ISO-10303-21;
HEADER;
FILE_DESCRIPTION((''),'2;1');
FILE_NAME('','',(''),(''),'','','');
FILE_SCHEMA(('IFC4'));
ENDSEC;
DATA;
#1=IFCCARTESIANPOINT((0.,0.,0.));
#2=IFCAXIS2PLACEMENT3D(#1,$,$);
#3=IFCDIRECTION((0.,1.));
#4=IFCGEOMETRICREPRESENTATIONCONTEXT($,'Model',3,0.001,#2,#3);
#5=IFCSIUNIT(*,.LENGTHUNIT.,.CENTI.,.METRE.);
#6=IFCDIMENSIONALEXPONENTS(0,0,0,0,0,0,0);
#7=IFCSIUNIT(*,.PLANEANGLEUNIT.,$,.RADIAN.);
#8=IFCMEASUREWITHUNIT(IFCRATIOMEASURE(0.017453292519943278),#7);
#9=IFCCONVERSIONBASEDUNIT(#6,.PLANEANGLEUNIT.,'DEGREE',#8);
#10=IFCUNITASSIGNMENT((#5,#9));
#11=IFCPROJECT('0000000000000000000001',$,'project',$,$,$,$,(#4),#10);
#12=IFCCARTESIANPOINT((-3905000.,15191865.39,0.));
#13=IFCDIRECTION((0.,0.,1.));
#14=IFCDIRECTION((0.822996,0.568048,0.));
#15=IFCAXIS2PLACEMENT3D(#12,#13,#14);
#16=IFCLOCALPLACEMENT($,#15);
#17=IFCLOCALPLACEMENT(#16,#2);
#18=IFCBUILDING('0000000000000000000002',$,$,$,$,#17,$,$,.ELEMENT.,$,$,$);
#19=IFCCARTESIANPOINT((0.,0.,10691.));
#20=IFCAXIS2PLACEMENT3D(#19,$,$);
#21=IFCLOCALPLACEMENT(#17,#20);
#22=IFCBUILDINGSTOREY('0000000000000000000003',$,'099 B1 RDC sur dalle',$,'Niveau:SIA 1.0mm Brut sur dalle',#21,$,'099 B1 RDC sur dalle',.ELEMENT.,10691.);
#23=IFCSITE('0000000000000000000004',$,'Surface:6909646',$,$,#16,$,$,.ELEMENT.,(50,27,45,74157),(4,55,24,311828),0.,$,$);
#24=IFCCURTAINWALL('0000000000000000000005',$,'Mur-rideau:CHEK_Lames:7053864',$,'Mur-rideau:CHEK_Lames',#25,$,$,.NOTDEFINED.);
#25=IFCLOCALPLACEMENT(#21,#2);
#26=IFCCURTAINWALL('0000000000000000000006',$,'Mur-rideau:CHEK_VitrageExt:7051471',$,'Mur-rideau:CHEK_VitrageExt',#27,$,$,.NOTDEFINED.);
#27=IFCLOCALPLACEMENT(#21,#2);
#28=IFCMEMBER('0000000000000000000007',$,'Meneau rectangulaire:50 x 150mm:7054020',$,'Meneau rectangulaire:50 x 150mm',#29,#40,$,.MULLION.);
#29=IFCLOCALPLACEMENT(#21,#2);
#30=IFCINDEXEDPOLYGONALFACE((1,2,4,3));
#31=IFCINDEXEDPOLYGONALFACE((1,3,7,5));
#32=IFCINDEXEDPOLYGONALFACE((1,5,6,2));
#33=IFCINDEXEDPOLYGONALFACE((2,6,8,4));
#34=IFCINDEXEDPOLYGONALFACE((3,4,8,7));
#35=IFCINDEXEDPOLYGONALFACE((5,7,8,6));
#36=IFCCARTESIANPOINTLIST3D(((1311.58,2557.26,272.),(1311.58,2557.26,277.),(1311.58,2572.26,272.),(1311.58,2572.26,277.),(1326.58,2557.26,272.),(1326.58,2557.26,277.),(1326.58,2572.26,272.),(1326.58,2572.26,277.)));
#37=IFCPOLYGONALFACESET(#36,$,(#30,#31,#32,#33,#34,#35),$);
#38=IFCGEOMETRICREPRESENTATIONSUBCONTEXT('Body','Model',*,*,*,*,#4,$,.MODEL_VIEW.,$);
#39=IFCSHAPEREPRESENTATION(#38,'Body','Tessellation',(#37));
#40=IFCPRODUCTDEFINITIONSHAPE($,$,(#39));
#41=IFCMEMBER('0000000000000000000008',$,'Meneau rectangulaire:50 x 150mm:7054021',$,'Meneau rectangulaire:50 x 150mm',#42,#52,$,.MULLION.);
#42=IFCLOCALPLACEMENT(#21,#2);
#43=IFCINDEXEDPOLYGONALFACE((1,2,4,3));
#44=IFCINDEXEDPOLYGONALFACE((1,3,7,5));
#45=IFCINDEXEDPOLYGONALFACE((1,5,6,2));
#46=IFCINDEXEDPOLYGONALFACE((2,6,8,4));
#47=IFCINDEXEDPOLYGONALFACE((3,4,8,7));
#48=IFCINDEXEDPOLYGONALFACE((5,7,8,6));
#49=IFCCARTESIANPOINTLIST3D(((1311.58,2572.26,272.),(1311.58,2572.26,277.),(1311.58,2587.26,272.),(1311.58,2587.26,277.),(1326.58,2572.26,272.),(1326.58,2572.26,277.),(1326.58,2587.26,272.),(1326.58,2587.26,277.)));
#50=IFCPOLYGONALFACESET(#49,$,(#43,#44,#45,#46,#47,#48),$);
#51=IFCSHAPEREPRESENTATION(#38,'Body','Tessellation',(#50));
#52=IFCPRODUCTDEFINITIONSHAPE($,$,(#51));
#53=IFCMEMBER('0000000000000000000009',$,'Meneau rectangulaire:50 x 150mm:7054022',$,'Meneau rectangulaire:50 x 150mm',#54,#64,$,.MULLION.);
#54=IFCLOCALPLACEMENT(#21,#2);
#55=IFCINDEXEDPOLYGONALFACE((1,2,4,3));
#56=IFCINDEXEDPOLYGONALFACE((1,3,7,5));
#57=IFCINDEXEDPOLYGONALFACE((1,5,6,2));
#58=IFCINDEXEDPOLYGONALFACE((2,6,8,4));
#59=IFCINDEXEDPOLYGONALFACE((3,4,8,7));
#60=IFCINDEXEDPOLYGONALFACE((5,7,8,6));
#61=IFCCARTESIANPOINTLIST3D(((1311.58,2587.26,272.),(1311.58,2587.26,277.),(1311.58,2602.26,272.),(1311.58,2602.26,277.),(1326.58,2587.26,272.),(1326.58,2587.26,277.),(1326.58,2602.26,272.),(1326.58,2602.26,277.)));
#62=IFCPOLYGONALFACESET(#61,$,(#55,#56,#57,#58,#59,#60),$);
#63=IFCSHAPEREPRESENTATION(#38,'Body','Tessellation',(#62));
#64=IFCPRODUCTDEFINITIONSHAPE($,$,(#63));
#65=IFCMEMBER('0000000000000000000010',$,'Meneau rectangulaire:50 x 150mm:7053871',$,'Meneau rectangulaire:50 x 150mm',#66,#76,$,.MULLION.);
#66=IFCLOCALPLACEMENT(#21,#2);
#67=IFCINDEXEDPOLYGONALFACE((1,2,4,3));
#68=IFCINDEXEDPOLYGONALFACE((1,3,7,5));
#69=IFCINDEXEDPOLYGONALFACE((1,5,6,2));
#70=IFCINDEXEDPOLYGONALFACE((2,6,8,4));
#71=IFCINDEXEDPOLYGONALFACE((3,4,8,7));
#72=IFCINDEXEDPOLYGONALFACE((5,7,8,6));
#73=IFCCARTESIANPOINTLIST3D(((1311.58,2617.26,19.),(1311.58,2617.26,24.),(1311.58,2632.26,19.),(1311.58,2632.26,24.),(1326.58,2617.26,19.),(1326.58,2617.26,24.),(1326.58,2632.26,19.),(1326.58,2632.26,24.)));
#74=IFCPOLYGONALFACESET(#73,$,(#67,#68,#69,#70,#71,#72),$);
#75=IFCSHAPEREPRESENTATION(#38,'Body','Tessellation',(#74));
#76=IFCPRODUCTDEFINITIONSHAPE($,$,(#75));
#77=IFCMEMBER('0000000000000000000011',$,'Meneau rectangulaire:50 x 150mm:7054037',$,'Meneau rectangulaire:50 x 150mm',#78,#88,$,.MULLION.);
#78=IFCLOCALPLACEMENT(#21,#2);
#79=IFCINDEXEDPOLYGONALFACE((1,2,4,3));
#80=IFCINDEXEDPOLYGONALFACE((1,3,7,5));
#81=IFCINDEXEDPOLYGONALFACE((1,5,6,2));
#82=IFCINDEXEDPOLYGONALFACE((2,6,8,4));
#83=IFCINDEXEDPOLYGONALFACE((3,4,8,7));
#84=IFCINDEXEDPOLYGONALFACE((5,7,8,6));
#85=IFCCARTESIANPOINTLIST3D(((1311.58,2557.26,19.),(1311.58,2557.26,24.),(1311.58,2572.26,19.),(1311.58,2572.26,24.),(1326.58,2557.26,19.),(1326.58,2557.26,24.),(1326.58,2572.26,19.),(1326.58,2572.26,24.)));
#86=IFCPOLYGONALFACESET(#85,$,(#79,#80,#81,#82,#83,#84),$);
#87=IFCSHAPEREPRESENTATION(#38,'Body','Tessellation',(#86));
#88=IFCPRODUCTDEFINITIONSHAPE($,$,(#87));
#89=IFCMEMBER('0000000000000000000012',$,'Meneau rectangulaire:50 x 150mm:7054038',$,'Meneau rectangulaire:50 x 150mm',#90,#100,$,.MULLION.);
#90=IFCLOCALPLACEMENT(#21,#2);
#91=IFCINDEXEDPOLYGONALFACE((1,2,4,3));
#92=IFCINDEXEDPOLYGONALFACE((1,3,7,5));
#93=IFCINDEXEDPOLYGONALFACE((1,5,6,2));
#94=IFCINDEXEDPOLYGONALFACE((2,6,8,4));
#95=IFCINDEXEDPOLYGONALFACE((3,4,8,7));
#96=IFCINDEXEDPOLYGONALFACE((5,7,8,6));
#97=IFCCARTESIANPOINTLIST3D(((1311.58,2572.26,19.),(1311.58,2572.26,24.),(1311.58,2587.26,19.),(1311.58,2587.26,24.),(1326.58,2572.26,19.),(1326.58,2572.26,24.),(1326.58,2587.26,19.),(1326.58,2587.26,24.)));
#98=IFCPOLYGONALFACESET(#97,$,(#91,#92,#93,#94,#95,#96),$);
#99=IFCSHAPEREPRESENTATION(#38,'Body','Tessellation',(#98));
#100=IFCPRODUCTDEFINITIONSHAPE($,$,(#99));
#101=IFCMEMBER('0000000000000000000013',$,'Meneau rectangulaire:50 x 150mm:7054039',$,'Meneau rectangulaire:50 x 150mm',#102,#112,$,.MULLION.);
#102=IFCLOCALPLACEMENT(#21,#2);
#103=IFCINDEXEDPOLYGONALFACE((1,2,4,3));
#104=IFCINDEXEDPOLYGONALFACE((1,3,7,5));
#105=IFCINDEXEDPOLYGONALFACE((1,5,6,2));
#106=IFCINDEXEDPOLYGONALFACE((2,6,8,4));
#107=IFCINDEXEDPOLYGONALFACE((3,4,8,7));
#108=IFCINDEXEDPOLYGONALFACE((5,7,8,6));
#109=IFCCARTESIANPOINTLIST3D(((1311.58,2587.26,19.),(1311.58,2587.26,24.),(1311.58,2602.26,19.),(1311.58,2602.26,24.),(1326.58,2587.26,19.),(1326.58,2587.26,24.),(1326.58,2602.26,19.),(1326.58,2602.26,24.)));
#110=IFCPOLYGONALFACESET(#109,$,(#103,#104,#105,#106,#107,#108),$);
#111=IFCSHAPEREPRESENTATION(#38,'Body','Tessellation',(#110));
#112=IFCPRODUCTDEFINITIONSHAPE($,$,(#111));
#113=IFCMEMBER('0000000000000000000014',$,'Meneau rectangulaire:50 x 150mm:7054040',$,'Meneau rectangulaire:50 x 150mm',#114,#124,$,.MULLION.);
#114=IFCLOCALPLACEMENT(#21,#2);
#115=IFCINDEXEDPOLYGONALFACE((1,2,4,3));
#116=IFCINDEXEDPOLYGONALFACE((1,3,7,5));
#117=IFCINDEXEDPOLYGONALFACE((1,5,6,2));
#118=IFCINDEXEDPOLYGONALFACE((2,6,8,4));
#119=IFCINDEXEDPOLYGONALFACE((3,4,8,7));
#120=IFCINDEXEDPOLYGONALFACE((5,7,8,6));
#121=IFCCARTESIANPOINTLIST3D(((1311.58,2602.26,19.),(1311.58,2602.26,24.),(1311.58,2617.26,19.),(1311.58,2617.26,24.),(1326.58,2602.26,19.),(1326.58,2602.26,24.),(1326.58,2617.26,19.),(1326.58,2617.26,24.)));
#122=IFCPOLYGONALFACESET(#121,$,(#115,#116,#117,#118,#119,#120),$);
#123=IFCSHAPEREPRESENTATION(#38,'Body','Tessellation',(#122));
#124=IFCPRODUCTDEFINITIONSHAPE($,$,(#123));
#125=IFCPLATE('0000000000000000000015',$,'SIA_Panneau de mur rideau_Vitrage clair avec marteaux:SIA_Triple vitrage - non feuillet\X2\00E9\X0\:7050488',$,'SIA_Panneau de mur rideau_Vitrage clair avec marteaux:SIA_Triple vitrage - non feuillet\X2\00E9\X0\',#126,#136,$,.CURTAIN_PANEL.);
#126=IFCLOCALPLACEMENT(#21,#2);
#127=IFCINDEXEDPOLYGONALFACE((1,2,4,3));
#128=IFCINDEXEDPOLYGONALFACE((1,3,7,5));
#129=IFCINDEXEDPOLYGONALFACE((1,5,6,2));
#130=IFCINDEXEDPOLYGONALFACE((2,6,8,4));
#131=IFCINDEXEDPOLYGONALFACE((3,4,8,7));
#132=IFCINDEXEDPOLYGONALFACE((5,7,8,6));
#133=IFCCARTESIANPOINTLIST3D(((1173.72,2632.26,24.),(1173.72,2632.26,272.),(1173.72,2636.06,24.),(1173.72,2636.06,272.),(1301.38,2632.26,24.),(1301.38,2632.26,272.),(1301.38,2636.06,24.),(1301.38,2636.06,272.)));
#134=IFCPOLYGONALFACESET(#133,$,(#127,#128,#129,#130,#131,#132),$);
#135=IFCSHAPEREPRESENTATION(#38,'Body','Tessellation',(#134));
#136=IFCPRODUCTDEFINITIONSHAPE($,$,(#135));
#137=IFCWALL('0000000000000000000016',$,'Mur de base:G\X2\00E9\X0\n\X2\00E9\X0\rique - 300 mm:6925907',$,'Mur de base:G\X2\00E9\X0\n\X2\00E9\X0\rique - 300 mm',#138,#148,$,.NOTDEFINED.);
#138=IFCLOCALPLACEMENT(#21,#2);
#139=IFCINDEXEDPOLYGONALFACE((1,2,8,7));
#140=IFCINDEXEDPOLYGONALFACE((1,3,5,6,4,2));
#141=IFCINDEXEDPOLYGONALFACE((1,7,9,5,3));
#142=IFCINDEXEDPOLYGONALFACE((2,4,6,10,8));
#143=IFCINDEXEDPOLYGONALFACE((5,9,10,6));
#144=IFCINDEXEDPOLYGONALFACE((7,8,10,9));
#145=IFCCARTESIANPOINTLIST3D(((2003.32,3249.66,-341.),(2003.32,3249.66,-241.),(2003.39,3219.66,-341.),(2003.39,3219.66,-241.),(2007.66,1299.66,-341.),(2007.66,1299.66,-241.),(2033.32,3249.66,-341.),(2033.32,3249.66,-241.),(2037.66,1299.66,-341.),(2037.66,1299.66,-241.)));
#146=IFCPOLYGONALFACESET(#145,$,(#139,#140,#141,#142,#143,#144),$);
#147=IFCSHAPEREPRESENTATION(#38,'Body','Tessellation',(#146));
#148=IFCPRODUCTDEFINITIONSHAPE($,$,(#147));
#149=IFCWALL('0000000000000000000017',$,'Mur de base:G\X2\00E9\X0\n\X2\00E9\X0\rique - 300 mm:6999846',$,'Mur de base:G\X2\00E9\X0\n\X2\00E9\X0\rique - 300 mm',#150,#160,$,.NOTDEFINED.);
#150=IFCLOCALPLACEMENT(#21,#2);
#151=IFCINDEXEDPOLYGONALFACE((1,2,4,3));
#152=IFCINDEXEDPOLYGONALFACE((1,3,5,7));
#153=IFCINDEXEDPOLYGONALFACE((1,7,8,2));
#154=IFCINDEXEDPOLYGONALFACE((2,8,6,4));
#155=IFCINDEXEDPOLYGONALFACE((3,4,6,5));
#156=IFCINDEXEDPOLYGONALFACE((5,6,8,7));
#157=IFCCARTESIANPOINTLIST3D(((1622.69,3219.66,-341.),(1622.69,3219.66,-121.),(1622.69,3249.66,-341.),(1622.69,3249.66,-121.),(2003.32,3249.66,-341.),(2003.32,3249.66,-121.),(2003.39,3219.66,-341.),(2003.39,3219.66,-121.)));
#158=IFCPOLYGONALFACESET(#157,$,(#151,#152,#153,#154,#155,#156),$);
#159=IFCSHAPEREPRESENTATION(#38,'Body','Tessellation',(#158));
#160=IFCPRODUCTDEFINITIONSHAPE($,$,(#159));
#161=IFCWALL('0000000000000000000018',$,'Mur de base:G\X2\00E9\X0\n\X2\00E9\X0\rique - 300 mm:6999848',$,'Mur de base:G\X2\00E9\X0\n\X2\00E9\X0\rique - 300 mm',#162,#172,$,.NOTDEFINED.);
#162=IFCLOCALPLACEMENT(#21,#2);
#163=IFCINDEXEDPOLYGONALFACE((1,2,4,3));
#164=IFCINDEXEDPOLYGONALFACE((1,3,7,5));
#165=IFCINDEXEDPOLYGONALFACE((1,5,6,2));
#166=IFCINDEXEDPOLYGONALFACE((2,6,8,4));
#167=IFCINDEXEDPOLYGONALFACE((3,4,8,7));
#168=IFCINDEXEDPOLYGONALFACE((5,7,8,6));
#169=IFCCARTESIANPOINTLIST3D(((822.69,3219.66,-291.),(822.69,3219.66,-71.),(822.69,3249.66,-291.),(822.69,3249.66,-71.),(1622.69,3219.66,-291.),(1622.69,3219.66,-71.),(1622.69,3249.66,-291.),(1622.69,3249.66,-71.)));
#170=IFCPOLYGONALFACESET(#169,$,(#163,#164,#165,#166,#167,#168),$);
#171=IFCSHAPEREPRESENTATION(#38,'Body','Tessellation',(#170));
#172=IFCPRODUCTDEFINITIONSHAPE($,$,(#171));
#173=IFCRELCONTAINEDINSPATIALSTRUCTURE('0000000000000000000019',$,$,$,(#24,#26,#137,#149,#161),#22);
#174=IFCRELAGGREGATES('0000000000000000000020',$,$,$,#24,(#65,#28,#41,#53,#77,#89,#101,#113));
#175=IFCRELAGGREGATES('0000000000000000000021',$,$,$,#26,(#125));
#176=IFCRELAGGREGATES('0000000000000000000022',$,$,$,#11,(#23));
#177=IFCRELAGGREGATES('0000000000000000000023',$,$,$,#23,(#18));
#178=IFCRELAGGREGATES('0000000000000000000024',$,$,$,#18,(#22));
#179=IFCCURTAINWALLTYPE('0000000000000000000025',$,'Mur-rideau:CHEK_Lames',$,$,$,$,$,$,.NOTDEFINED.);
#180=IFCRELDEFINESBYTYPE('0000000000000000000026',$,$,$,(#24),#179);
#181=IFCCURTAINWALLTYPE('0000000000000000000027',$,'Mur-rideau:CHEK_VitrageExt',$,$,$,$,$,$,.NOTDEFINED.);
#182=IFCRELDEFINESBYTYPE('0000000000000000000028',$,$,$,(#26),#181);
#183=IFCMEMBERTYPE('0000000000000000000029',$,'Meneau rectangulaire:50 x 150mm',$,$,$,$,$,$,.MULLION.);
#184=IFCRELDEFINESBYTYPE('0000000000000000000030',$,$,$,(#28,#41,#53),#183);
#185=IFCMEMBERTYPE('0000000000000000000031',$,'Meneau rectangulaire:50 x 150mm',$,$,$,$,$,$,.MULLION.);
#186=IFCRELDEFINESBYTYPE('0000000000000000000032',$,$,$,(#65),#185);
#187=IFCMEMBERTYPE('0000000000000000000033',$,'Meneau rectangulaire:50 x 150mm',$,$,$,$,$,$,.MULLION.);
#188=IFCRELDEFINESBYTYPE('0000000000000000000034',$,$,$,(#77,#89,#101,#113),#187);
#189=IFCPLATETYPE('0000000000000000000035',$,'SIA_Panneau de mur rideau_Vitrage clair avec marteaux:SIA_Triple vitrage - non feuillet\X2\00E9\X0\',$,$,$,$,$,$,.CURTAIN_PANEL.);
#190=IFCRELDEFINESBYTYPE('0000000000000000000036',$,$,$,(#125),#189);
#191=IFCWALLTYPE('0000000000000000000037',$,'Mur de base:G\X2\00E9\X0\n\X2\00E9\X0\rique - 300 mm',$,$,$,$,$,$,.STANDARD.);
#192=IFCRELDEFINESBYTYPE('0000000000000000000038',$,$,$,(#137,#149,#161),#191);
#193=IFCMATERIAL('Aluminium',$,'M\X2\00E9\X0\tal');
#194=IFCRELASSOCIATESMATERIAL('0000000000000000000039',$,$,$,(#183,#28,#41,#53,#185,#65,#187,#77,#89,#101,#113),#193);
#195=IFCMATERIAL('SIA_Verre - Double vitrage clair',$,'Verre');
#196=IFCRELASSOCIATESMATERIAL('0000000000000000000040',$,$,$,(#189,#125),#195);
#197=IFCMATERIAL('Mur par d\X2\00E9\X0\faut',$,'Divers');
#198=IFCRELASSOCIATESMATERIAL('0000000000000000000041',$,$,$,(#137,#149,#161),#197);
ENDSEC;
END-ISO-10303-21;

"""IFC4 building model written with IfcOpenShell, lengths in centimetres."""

from ifc_helpers import new_model, entity, si_unit, converted_unit, direction, frame, origin, place, context, subcontext, project, spatial, indexed_curve, outline, extrude, source, transform, mapped, material, type_object, type_shapes, element, aggregate, save


model = new_model("IFC4")

# Units and contexts
model_context = context("Model", 3, precision=0.001, world=origin(), true_north=direction((0.0, 1.0)))
body_context = subcontext(model_context, "Body", "Model", "MODEL_VIEW")
ifc_project = project(units=[si_unit("LENGTHUNIT", "METRE", prefix="CENTI"), converted_unit("PLANEANGLEUNIT", "DEGREE", entity("IfcRatioMeasure", 0.017453292519943278), si_unit("PLANEANGLEUNIT", "RADIAN"), dimensions=[0, 0, 0, 0, 0, 0, 0])], contexts=[model_context])

# Site, building, storey
site_placement = place(None, frame((-3905000.0, 15191865.39, 0.0), z_axis=(0.0, 0.0, 1.0), x_axis=(0.822996, 0.568048, 0.0)))
site = spatial("IfcSite", under=ifc_project, at=site_placement, Name="Surface:6909646", CompositionType="ELEMENT", RefLatitude=(50, 27, 45, 74157), RefLongitude=(4, 55, 24, 311828), RefElevation=0.0)
building_placement = place(site_placement, origin())
building = spatial("IfcBuilding", under=site, at=building_placement, CompositionType="ELEMENT")
storey_placement = place(building_placement, frame((0.0, 0.0, 10691.0)))
storey = spatial("IfcBuildingStorey", under=building, at=storey_placement, Name="099 B1 RDC sur dalle", ObjectType="Niveau:SIA 1.0mm Brut sur dalle", LongName="099 B1 RDC sur dalle", CompositionType="ELEMENT", Elevation=10691.0)

# Curtain wall
curtain_wall_type_1 = type_object("IfcCurtainWallType", Name="Mur-rideau:CHEK_Lames", PredefinedType="NOTDEFINED")
curtain_wall_1_placement = place(storey_placement, frame((0.0, 0.0, -10691.0)))
curtain_wall_1 = element("IfcCurtainWall", 1, at=curtain_wall_1_placement, inside=storey, type_object=curtain_wall_type_1, Name="Mur-rideau:CHEK_Lames:7053864", ObjectType="Mur-rideau:CHEK_Lames", PredefinedType="NOTDEFINED")
ifc_material_1 = material(Name="Aluminium", Category="Métal")

# Curtain wall
curtain_wall_type_2 = type_object("IfcCurtainWallType", Name="Mur-rideau:CHEK_VitrageExt", PredefinedType="NOTDEFINED")
curtain_wall_2_placement = place(storey_placement, frame((0.0, 0.0, -10691.0)))
curtain_wall_2 = element("IfcCurtainWall", 2, at=curtain_wall_2_placement, inside=storey, type_object=curtain_wall_type_2, Name="Mur-rideau:CHEK_VitrageExt:7051471", ObjectType="Mur-rideau:CHEK_VitrageExt", PredefinedType="NOTDEFINED")

# Members
member_type_1 = type_object("IfcMemberType", Name="Meneau rectangulaire:50 x 150mm", PredefinedType="MULLION", material=ifc_material_1)
shared_shape_1 = source(origin(), body_context, "Body", "SweptSolid", [
    extrude(outline(indexed_curve([(-7.5, -2.5), (7.5, -2.5), (7.5, 2.5), (-7.5, 2.5), (-7.5, -2.5)], self_intersect=False)), frame((-2.5, -6.0, -15.0), z_axis=(0.0, 0.0, 1.0), x_axis=(0.0, -1.0, 0.0)), (0.0, 0.0, 1.0), 15.0),
])
type_shapes(member_type_1, [shared_shape_1])
member_1_placement = place(curtain_wall_1_placement, frame((1325.08, 2572.26, 10968.0), z_axis=(0.0, 1.0, 0.0), x_axis=(0.0, 0.0, 1.0)))
member_1 = element("IfcMember", 3, at=member_1_placement, type_object=member_type_1, material=ifc_material_1, Name="Meneau rectangulaire:50 x 150mm:7054020", ObjectType="Meneau rectangulaire:50 x 150mm", PredefinedType="MULLION", context=body_context, shape_type="MappedRepresentation", body=[
    mapped(shared_shape_1, transform((0.0, 0.0, 0.0), scale=1.0)),
])
member_2_placement = place(curtain_wall_1_placement, frame((1325.08, 2587.26, 10968.0), z_axis=(0.0, 1.0, 0.0), x_axis=(0.0, 0.0, 1.0)))
member_2 = element("IfcMember", 4, at=member_2_placement, type_object=member_type_1, material=ifc_material_1, Name="Meneau rectangulaire:50 x 150mm:7054021", ObjectType="Meneau rectangulaire:50 x 150mm", PredefinedType="MULLION", context=body_context, shape_type="MappedRepresentation", body=[
    mapped(shared_shape_1, transform((0.0, 0.0, 0.0), scale=1.0)),
])
member_3_placement = place(curtain_wall_1_placement, frame((1325.08, 2602.26, 10968.0), z_axis=(0.0, 1.0, 0.0), x_axis=(0.0, 0.0, 1.0)))
member_3 = element("IfcMember", 5, at=member_3_placement, type_object=member_type_1, material=ifc_material_1, Name="Meneau rectangulaire:50 x 150mm:7054022", ObjectType="Meneau rectangulaire:50 x 150mm", PredefinedType="MULLION", context=body_context, shape_type="MappedRepresentation", body=[
    mapped(shared_shape_1, transform((0.0, 0.0, 0.0), scale=1.0)),
])
member_type_2 = type_object("IfcMemberType", Name="Meneau rectangulaire:50 x 150mm", PredefinedType="MULLION", material=ifc_material_1)
shared_shape_2 = source(origin(), body_context, "Body", "SweptSolid", [
    extrude(outline(indexed_curve([(-7.5, -2.5), (7.5, -2.5), (7.5, 2.5), (-7.5, 2.5), (-7.5, -2.5)], self_intersect=False)), frame((-2.5, -6.0, -15.0), z_axis=(0.0, 0.0, 1.0), x_axis=(0.0, -1.0, 0.0)), (0.0, 0.0, 1.0), 15.0),
])
type_shapes(member_type_2, [shared_shape_2])
member_4_placement = place(curtain_wall_1_placement, frame((1325.08, 2617.26, 10710.0), z_axis=(0.0, -1.0, 0.0), x_axis=(0.0, 0.0, -1.0)))
member_4 = element("IfcMember", 6, at=member_4_placement, type_object=member_type_2, material=ifc_material_1, Name="Meneau rectangulaire:50 x 150mm:7053871", ObjectType="Meneau rectangulaire:50 x 150mm", PredefinedType="MULLION", context=body_context, shape_type="MappedRepresentation", body=[
    mapped(shared_shape_2, transform((0.0, 0.0, 0.0), scale=1.0)),
])
member_type_3 = type_object("IfcMemberType", Name="Meneau rectangulaire:50 x 150mm", PredefinedType="MULLION", material=ifc_material_1)
shared_shape_3 = source(origin(), body_context, "Body", "SweptSolid", [
    extrude(outline(indexed_curve([(-7.5, -2.5), (7.5, -2.5), (7.5, 2.5), (-7.5, 2.5), (-7.5, -2.5)], self_intersect=False)), frame((-2.5, -6.0, -15.0), z_axis=(0.0, 0.0, 1.0), x_axis=(0.0, -1.0, 0.0)), (0.0, 0.0, 1.0), 15.0),
])
type_shapes(member_type_3, [shared_shape_3])
member_5_placement = place(curtain_wall_1_placement, frame((1325.08, 2557.26, 10710.0), z_axis=(0.0, -1.0, 0.0), x_axis=(0.0, 0.0, -1.0)))
member_5 = element("IfcMember", 7, at=member_5_placement, type_object=member_type_3, material=ifc_material_1, Name="Meneau rectangulaire:50 x 150mm:7054037", ObjectType="Meneau rectangulaire:50 x 150mm", PredefinedType="MULLION", context=body_context, shape_type="MappedRepresentation", body=[
    mapped(shared_shape_3, transform((0.0, 0.0, 0.0), scale=1.0)),
])
member_6_placement = place(curtain_wall_1_placement, frame((1325.08, 2572.26, 10710.0), z_axis=(0.0, -1.0, 0.0), x_axis=(0.0, 0.0, -1.0)))
member_6 = element("IfcMember", 8, at=member_6_placement, type_object=member_type_3, material=ifc_material_1, Name="Meneau rectangulaire:50 x 150mm:7054038", ObjectType="Meneau rectangulaire:50 x 150mm", PredefinedType="MULLION", context=body_context, shape_type="MappedRepresentation", body=[
    mapped(shared_shape_3, transform((0.0, 0.0, 0.0), scale=1.0)),
])
member_7_placement = place(curtain_wall_1_placement, frame((1325.08, 2587.26, 10710.0), z_axis=(0.0, -1.0, 0.0), x_axis=(0.0, 0.0, -1.0)))
member_7 = element("IfcMember", 9, at=member_7_placement, type_object=member_type_3, material=ifc_material_1, Name="Meneau rectangulaire:50 x 150mm:7054039", ObjectType="Meneau rectangulaire:50 x 150mm", PredefinedType="MULLION", context=body_context, shape_type="MappedRepresentation", body=[
    mapped(shared_shape_3, transform((0.0, 0.0, 0.0), scale=1.0)),
])
member_8_placement = place(curtain_wall_1_placement, frame((1325.08, 2602.26, 10710.0), z_axis=(0.0, -1.0, 0.0), x_axis=(0.0, 0.0, -1.0)))
member_8 = element("IfcMember", 10, at=member_8_placement, type_object=member_type_3, material=ifc_material_1, Name="Meneau rectangulaire:50 x 150mm:7054040", ObjectType="Meneau rectangulaire:50 x 150mm", PredefinedType="MULLION", context=body_context, shape_type="MappedRepresentation", body=[
    mapped(shared_shape_3, transform((0.0, 0.0, 0.0), scale=1.0)),
])
aggregate(curtain_wall_1, [member_4, member_1, member_2, member_3, member_5, member_6, member_7, member_8])

# Plate
ifc_material_2 = material(Name="SIA_Verre - Double vitrage clair", Category="Verre")
plate_type = type_object("IfcPlateType", Name="SIA_Panneau de mur rideau_Vitrage clair avec marteaux:SIA_Triple vitrage - non feuilleté", PredefinedType="CURTAIN_PANEL", material=ifc_material_2)
shared_shape_4 = source(origin(), body_context, "Body", "SweptSolid", [
    extrude(outline(indexed_curve([(-63.83, -1.9), (63.83, -1.9), (63.83, 1.9), (-63.83, 1.9), (-63.83, -1.9)], self_intersect=False)), frame((0.0, 1.9, 0.0), z_axis=(0.0, 0.0, 1.0), x_axis=(-1.0, 0.0, 0.0)), (0.0, 0.0, 1.0), 248.0),
])
type_shapes(plate_type, [shared_shape_4])
plate_placement = place(curtain_wall_2_placement, frame((1237.55, 2632.26, 10715.0)))
plate = element("IfcPlate", 11, at=plate_placement, type_object=plate_type, material=ifc_material_2, Name="SIA_Panneau de mur rideau_Vitrage clair avec marteaux:SIA_Triple vitrage - non feuilleté:7050488", ObjectType="SIA_Panneau de mur rideau_Vitrage clair avec marteaux:SIA_Triple vitrage - non feuilleté", PredefinedType="CURTAIN_PANEL", context=body_context, shape_type="MappedRepresentation", body=[
    mapped(shared_shape_4, transform((0.0, 0.0, 0.0), scale=1.0)),
])
aggregate(curtain_wall_2, [plate])

# Walls
ifc_material_3 = material(Name="Mur par défaut", Category="Divers")
wall_type_1 = type_object("IfcWallType", Name="Mur de base:Générique - 300 mm", PredefinedType="STANDARD")
wall_1_placement = place(storey_placement, frame((2018.32, 3249.7, -341.0), z_axis=(0.0, 0.0, 1.0), x_axis=(0.002225, -0.999998, 0.0)))
element("IfcWall", 12, at=wall_1_placement, inside=storey, type_object=wall_type_1, material=ifc_material_3, Name="Mur de base:Générique - 300 mm:6925907", ObjectType="Mur de base:Générique - 300 mm", PredefinedType="NOTDEFINED", context=body_context, shape_type="SweptSolid", body=[
    extrude(outline(indexed_curve([(1950.0, -15.0), (1950.07, 15.0), (0.07, 15.0), (0.0, -15.0), (30.0, -15.0), (1950.0, -15.0)], self_intersect=False)), origin(), (0.0, 0.0, 1.0), 100.0),
])
wall_2_placement = place(storey_placement, frame((2003.39, 3234.66, -341.0), z_axis=(0.0, 0.0, 1.0), x_axis=(-1.0, 0.0, 0.0)))
element("IfcWall", 13, at=wall_2_placement, inside=storey, type_object=wall_type_1, material=ifc_material_3, Name="Mur de base:Générique - 300 mm:6999846", ObjectType="Mur de base:Générique - 300 mm", PredefinedType="NOTDEFINED", context=body_context, shape_type="SweptSolid", body=[
    extrude(outline(indexed_curve([(380.69, -15.0), (380.69, 15.0), (0.0, 15.0), (0.07, -15.0), (380.69, -15.0)], self_intersect=False)), origin(), (0.0, 0.0, 1.0), 220.0),
])
wall_3_placement = place(storey_placement, frame((1622.69, 3234.66, -291.0), z_axis=(0.0, 0.0, 1.0), x_axis=(-1.0, 0.0, 0.0)))
element("IfcWall", 14, at=wall_3_placement, inside=storey, type_object=wall_type_1, material=ifc_material_3, Name="Mur de base:Générique - 300 mm:6999848", ObjectType="Mur de base:Générique - 300 mm", PredefinedType="NOTDEFINED", context=body_context, shape_type="SweptSolid", body=[
    extrude(outline(indexed_curve([(800.0, 15.0), (0.0, 15.0), (0.0, -15.0), (800.0, -15.0), (800.0, 15.0)], self_intersect=False)), origin(), (0.0, 0.0, 1.0), 220.0),
])

save(model, "model.ifc")
